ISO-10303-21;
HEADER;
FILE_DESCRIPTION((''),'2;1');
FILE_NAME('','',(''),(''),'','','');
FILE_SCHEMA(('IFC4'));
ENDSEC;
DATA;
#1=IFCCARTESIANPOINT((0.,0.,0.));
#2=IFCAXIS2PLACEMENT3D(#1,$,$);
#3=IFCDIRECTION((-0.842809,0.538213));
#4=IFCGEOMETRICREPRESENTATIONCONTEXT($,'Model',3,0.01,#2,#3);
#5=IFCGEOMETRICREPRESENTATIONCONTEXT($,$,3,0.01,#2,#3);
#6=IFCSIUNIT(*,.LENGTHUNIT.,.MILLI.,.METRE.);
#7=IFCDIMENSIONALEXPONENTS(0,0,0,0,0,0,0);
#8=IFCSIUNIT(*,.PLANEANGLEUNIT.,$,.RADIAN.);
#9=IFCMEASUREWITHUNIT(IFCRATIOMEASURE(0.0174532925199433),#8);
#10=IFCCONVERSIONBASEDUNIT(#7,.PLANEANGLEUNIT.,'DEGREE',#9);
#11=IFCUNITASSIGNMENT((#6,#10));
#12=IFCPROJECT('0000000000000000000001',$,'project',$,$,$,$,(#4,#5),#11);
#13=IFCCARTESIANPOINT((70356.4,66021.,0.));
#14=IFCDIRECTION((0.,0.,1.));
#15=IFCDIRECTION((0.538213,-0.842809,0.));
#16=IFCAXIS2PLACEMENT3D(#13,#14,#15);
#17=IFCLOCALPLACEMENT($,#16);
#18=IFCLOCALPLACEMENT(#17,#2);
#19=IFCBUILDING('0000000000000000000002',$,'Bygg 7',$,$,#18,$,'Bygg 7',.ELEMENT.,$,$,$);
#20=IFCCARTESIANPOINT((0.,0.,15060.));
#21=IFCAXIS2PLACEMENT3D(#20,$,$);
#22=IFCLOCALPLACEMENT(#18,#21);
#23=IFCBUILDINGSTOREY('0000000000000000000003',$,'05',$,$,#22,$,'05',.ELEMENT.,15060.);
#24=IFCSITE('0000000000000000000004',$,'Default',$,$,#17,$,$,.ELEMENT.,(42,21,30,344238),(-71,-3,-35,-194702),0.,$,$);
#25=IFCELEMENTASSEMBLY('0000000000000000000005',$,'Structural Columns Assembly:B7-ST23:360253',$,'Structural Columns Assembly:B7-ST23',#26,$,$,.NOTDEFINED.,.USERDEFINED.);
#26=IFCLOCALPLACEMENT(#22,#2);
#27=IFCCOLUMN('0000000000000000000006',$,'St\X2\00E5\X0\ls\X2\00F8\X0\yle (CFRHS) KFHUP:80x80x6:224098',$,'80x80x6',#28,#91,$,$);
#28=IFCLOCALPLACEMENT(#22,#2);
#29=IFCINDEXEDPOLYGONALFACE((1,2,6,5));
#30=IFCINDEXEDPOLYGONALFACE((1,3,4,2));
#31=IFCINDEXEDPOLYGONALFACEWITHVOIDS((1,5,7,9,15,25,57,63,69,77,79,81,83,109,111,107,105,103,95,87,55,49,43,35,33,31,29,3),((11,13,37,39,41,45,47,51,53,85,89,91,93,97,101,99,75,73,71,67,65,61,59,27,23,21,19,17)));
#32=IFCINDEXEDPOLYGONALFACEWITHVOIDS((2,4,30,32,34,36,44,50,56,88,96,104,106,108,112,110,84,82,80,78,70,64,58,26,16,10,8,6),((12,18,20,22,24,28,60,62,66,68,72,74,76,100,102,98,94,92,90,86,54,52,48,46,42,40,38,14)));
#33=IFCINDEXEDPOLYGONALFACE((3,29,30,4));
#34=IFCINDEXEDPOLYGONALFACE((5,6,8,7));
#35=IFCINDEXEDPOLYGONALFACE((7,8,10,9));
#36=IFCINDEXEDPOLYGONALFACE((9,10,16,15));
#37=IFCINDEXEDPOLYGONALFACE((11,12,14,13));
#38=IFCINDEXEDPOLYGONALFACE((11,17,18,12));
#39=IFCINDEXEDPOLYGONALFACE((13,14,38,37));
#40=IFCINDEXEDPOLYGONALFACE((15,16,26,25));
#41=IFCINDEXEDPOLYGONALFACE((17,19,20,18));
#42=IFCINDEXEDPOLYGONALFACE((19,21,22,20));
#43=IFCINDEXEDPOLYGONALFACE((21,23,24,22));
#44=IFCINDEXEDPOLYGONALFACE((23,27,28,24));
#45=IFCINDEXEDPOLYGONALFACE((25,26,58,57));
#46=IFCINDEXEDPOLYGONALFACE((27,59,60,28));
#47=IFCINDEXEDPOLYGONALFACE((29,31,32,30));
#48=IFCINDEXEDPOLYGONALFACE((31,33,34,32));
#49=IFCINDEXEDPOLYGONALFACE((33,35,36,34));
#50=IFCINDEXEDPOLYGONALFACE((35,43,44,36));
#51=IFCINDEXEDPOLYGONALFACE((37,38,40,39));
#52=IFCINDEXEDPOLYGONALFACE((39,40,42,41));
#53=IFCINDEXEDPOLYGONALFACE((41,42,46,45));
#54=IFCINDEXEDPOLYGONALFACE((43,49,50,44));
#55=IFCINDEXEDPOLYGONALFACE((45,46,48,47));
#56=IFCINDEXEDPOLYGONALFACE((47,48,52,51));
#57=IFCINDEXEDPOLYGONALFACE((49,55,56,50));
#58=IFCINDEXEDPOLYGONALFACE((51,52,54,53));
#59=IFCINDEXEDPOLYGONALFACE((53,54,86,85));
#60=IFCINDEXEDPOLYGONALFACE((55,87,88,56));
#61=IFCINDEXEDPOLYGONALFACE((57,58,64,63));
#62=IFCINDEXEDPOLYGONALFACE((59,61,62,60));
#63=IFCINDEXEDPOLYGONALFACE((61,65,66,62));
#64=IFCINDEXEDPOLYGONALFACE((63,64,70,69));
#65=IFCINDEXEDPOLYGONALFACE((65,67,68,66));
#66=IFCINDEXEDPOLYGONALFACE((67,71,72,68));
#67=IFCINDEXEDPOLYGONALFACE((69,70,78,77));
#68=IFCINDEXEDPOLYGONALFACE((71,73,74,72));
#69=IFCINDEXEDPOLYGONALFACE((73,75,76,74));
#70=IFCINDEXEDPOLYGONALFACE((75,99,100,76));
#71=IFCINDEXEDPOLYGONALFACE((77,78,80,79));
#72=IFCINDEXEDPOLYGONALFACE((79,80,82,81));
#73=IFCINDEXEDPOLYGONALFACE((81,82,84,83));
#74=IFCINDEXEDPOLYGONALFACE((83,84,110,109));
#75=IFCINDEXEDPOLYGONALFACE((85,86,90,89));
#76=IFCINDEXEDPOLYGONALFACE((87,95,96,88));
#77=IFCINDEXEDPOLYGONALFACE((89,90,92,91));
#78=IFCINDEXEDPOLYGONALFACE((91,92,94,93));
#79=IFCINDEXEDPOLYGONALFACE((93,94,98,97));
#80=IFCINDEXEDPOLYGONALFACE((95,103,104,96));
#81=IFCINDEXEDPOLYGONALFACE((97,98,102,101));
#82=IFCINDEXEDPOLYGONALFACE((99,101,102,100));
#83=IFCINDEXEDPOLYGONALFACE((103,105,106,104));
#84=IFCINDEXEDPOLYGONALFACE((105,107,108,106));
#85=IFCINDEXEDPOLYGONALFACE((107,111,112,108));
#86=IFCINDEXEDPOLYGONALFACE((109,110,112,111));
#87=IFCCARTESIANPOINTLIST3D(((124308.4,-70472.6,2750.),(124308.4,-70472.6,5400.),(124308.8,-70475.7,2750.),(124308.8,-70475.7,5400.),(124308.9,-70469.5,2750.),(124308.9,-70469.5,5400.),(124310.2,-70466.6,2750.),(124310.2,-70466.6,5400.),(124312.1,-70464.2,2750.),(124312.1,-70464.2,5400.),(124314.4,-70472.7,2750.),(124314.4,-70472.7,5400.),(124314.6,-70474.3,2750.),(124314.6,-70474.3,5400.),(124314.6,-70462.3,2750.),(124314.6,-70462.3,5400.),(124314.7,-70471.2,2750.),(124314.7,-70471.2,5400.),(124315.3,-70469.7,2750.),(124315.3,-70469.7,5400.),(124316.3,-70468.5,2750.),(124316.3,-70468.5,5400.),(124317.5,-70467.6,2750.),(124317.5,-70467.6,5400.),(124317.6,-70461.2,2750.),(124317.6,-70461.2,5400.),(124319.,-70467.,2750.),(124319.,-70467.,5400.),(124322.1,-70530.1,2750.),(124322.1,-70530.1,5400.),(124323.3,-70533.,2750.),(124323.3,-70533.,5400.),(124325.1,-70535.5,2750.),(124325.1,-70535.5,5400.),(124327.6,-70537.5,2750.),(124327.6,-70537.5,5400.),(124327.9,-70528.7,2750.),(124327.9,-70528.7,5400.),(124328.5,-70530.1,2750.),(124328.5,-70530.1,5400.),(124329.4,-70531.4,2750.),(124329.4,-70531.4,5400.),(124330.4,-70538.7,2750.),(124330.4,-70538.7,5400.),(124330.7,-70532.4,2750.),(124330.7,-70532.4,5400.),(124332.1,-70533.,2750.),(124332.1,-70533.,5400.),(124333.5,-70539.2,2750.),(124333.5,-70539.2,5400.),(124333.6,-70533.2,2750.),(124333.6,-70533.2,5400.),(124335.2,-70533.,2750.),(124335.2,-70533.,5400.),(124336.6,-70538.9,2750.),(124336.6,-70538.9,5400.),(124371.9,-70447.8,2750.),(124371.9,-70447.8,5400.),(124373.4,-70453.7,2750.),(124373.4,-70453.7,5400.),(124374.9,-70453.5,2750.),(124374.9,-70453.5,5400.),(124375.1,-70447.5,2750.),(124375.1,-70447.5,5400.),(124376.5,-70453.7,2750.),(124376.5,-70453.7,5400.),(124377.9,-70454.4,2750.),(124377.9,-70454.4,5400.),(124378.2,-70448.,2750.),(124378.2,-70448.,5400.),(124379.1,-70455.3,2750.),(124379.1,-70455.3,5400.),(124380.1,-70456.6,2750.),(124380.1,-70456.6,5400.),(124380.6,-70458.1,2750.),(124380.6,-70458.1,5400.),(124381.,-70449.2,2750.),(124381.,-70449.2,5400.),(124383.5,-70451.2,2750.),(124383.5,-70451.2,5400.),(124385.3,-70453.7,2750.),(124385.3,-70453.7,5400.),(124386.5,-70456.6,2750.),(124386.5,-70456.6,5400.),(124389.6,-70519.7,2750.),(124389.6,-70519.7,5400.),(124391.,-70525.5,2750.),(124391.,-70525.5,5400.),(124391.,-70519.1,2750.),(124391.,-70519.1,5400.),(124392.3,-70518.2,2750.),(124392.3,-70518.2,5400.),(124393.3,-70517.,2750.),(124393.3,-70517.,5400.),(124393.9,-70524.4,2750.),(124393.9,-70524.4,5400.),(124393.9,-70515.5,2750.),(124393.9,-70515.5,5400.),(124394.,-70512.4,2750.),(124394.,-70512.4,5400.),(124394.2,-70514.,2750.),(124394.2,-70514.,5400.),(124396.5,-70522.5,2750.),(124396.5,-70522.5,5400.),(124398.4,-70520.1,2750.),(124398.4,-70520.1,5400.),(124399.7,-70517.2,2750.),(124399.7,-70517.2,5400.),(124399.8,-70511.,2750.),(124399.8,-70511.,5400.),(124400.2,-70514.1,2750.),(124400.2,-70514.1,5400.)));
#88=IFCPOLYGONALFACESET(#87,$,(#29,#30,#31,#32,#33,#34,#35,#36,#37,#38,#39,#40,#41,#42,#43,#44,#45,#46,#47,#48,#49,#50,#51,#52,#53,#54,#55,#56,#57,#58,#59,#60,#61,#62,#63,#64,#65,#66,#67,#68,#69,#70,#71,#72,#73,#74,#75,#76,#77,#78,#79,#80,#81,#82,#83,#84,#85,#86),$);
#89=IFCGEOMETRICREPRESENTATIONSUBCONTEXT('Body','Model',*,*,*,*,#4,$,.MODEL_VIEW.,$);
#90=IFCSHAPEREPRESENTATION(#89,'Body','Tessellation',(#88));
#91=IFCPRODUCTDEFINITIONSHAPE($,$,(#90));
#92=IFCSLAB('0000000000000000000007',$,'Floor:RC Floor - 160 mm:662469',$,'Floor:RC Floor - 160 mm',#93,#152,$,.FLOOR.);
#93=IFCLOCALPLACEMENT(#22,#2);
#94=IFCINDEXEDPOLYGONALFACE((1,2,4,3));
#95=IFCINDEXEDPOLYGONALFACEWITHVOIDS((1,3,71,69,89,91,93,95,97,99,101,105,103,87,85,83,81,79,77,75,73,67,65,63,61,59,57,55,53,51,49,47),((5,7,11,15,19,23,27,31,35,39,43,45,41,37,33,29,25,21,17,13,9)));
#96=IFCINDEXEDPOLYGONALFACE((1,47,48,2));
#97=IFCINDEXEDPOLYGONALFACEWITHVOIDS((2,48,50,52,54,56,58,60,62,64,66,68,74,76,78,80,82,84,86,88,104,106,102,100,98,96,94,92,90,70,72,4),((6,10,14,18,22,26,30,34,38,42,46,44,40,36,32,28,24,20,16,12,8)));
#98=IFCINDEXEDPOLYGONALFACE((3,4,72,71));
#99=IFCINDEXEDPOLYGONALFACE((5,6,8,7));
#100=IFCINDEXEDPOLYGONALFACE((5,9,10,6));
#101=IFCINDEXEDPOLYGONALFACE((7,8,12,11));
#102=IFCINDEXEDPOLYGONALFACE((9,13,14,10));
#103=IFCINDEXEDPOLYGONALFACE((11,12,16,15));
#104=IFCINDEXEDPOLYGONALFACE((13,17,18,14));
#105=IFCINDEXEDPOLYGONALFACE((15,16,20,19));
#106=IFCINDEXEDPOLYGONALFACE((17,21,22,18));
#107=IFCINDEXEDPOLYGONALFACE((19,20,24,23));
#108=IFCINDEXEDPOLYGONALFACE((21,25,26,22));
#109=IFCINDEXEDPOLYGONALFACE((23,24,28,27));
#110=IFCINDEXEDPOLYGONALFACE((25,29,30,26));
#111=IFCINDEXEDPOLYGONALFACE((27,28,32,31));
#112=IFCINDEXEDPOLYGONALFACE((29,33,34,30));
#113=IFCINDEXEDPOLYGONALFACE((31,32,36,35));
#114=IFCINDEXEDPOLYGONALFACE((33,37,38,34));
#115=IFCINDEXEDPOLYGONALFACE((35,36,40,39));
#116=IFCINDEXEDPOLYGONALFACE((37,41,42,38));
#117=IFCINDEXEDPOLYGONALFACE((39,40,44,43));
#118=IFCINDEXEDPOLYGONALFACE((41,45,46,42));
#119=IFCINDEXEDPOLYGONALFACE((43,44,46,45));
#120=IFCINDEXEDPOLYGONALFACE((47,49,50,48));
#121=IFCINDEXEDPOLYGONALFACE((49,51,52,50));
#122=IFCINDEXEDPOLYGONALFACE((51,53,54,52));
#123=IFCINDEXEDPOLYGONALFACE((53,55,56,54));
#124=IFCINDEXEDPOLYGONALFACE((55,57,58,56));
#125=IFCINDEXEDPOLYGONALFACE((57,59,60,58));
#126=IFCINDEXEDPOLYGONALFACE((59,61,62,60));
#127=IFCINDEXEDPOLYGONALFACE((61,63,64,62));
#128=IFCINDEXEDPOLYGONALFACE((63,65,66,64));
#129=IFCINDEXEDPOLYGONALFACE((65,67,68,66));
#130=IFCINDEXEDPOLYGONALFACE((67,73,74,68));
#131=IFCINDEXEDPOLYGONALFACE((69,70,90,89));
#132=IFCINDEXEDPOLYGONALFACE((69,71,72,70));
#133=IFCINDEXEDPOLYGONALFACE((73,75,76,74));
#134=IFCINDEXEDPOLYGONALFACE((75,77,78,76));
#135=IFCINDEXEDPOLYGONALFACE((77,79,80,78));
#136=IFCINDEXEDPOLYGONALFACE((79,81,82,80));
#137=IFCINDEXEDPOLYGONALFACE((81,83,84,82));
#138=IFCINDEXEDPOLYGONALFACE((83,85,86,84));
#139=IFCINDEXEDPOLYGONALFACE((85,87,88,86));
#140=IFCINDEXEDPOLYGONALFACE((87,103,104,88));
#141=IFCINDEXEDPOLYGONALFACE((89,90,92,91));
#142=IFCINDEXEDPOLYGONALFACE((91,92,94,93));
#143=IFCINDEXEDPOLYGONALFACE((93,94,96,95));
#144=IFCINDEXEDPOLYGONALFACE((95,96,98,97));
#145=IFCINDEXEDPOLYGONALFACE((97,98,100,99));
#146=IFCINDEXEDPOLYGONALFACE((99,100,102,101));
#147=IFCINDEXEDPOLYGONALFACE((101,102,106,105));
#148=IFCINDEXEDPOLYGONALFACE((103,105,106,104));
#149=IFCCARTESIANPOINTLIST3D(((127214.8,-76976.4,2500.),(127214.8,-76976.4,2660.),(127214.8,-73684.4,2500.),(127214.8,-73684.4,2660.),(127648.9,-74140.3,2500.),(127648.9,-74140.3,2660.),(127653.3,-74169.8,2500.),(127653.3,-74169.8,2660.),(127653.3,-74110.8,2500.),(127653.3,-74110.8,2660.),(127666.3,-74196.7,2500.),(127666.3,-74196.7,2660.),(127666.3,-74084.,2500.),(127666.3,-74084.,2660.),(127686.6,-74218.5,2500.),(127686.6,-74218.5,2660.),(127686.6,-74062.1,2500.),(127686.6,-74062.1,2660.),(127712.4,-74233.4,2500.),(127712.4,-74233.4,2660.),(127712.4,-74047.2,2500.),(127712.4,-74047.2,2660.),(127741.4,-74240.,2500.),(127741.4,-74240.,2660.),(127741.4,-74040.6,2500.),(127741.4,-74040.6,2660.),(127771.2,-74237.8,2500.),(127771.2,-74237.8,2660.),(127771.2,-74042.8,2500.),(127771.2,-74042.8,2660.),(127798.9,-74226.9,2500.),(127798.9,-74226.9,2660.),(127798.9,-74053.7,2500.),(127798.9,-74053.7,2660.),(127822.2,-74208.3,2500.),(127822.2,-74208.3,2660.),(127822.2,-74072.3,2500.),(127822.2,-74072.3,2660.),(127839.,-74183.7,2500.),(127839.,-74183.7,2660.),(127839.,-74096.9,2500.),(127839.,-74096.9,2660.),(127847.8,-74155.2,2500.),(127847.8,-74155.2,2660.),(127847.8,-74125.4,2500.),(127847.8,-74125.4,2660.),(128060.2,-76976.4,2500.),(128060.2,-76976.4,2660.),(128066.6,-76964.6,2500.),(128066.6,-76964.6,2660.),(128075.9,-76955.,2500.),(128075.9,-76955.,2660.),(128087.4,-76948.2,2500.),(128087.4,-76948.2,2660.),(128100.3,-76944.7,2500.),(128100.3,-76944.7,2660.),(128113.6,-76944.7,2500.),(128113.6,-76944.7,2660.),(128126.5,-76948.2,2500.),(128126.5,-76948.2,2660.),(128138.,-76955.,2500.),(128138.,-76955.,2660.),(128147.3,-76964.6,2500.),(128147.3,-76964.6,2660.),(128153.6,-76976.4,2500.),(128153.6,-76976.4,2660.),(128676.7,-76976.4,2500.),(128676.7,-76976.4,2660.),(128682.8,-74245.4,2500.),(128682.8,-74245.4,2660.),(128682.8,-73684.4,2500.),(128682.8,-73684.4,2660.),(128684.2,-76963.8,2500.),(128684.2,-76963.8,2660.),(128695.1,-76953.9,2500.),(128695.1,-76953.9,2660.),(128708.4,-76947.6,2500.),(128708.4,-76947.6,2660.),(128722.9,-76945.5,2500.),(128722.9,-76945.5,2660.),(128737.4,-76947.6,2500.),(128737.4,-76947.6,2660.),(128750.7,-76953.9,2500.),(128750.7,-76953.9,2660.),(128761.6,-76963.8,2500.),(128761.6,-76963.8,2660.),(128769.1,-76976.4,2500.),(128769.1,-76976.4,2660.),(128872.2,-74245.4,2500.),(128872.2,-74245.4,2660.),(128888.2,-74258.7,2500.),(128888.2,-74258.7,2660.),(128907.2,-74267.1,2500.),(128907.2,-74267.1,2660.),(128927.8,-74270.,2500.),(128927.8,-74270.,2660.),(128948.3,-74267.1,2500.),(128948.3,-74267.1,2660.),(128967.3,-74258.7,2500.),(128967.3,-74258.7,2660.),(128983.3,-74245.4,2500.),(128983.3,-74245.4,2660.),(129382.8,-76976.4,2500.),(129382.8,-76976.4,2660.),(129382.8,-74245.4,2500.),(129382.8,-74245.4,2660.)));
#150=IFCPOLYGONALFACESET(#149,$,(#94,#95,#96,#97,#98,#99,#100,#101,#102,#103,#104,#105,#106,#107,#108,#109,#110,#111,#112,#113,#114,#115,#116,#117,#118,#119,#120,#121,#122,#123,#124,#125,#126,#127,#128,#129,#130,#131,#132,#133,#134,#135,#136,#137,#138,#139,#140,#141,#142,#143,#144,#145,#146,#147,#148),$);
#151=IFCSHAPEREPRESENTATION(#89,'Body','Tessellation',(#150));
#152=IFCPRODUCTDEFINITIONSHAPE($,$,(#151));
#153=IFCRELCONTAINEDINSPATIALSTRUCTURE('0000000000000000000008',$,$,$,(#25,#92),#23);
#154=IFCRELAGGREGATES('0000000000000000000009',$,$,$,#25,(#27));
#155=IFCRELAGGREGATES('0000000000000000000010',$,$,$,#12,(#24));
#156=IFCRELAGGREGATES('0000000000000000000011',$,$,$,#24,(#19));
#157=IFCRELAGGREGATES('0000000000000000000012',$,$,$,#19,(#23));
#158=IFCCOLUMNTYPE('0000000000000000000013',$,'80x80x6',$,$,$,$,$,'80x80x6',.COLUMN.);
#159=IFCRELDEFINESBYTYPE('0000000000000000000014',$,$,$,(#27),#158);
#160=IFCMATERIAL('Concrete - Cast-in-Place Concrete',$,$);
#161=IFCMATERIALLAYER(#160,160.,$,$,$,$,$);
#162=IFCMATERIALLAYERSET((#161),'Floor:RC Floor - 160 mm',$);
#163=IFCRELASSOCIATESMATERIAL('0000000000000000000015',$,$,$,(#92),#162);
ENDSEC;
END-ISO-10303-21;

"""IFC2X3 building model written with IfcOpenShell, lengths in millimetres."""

from ifc_helpers import new_model, entity, si_unit, converted_unit, direction, frame, frame_2d, origin, place, context, subcontext, project, spatial, polyline, circle_curve, parameter, trimmed, segment, composite_curve, circle, outline, extrude, source, transform, mapped, material, layer, layer_set, layer_usage, type_object, type_shapes, element, aggregate, save


model = new_model("IFC2X3")

# Units and contexts
model_context = context("Model", 3, precision=0.01, world=origin(), true_north=direction((-0.842809, 0.538213)))
context_of_model = context(None, 3, precision=0.01, world=origin(), true_north=direction((-0.842809, 0.538213)))
body_context = subcontext(model_context, "Body", "Model", "MODEL_VIEW")
ifc_project = project(units=[si_unit("LENGTHUNIT", "METRE", prefix="MILLI"), converted_unit("PLANEANGLEUNIT", "DEGREE", entity("IfcRatioMeasure", 0.0174532925199433), si_unit("PLANEANGLEUNIT", "RADIAN"), dimensions=[0, 0, 0, 0, 0, 0, 0])], contexts=[model_context, context_of_model])

# Site, building, storey
site_placement = place(None, frame((70356.4, 66021.0, 0.0), z_axis=(0.0, 0.0, 1.0), x_axis=(0.538213, -0.842809, 0.0)))
site = spatial("IfcSite", under=ifc_project, at=site_placement, Name="Default", CompositionType="ELEMENT", RefLatitude=(42, 21, 30, 344238), RefLongitude=(-71, -3, -35, -194702), RefElevation=0.0)
building_placement = place(site_placement, origin())
building = spatial("IfcBuilding", under=site, at=building_placement, Name="Bygg 7", LongName="Bygg 7", CompositionType="ELEMENT")
storey_placement = place(building_placement, frame((0.0, 0.0, 15060.0)))
storey = spatial("IfcBuildingStorey", under=building, at=storey_placement, Name="05", LongName="05", CompositionType="ELEMENT", Elevation=15060.0)

# Element assembly, column
assembly_1_placement = place(storey_placement, origin())
assembly_1 = element("IfcElementAssembly", 1, at=assembly_1_placement, inside=storey, Name="Structural Columns Assembly:B7-ST23:360253", ObjectType="Structural Columns Assembly:B7-ST23", AssemblyPlace="NOTDEFINED", PredefinedType="USERDEFINED")
column_type_1 = type_object("IfcColumnType", Name="80x80x6", ElementType="80x80x6", PredefinedType="COLUMN")
shared_shape_1 = source(origin(), body_context, "Body", "SweptSolid", [
    extrude(outline(composite_curve([segment(trimmed(circle_curve(frame_2d((-28.0, 28.0), x_axis=(1.0, 0.0)), 12.0), [parameter(90.0)], [parameter(180.0)], True, "PARAMETER"), True, "CONTINUOUS"), segment(polyline([(-40.0, 28.0), (-40.0, -28.0)]), True, "CONTINUOUS"), segment(trimmed(circle_curve(frame_2d((-28.0, -28.0), x_axis=(1.0, 0.0)), 12.0), [parameter(180.0)], [parameter(270.0)], True, "PARAMETER"), True, "CONTINUOUS"), segment(polyline([(-28.0, -40.0), (28.0, -40.0)]), True, "CONTINUOUS"), segment(trimmed(circle_curve(frame_2d((28.0, -28.0), x_axis=(1.0, 0.0)), 12.0), [parameter(270.0)], [parameter(0.0)], True, "PARAMETER"), True, "CONTINUOUS"), segment(polyline([(40.0, -28.0), (40.0, 28.0)]), True, "CONTINUOUS"), segment(trimmed(circle_curve(frame_2d((28.0, 28.0), x_axis=(1.0, 0.0)), 12.0), [parameter(0.0)], [parameter(90.0)], True, "PARAMETER"), True, "CONTINUOUS"), segment(polyline([(28.0, 40.0), (-28.0, 40.0)]), True, "CONTINUOUS")], self_intersect=False), holes=[composite_curve([segment(polyline([(-28.0, 34.0), (28.0, 34.0)]), True, "CONTINUOUS"), segment(trimmed(circle_curve(frame_2d((28.0, 28.0), x_axis=(1.0, 0.0)), 6.0), [parameter(360.0)], [parameter(90.0)], True, "PARAMETER"), False, "CONTINUOUS"), segment(polyline([(34.0, 28.0), (34.0, -28.0)]), True, "CONTINUOUS"), segment(trimmed(circle_curve(frame_2d((28.0, -28.0), x_axis=(1.0, 0.0)), 6.0), [parameter(270.0)], [parameter(360.0)], True, "PARAMETER"), False, "CONTINUOUS"), segment(polyline([(28.0, -34.0), (-28.0, -34.0)]), True, "CONTINUOUS"), segment(trimmed(circle_curve(frame_2d((-28.0, -28.0), x_axis=(1.0, 0.0)), 6.0), [parameter(180.0)], [parameter(270.0)], True, "PARAMETER"), False, "CONTINUOUS"), segment(polyline([(-34.0, -28.0), (-34.0, 28.0)]), True, "CONTINUOUS"), segment(trimmed(circle_curve(frame_2d((-28.0, 28.0), x_axis=(1.0, 0.0)), 6.0), [parameter(90.0)], [parameter(180.0)], True, "PARAMETER"), False, "CONTINUOUS")], self_intersect=False)]), frame((47.5, 47.5, 0.0), z_axis=(0.0, 0.0, 1.0), x_axis=(-0.971172, -0.238381, 0.0)), (0.0, 0.0, 1.0), 2650.0),
])
type_shapes(column_type_1, [shared_shape_1])
column_1_placement = place(assembly_1_placement, frame((124306.8, -70540.8, 2750.0)))
column_1 = element("IfcColumn", 2, at=column_1_placement, type_object=column_type_1, Name="Stålsøyle (CFRHS) KFHUP:80x80x6:224098", ObjectType="80x80x6", context=body_context, shape_type="MappedRepresentation", body=[
    mapped(shared_shape_1, transform((0.0, 0.0, 0.0), scale=1.0)),
])
aggregate(assembly_1, [column_1])

# Shared definitions
ifc_material_1 = material(Name="Concrete - Cast-in-Place Concrete")

# Slab, openings
ifc_layer_1 = layer(ifc_material_1, 160.0)
ifc_layer_set_1 = layer_set([ifc_layer_1], Name="Floor:RC Floor - 160 mm")
ifc_layer_usage_1 = layer_usage(ifc_layer_set_1, "AXIS3", "POSITIVE", 0.0)
slab_1_placement = place(storey_placement, frame((127214.8, -76976.4, 2500.0)))
slab_1 = element("IfcSlab", 3, at=slab_1_placement, inside=storey, material=ifc_layer_usage_1, Name="Floor:RC Floor - 160 mm:662469", ObjectType="Floor:RC Floor - 160 mm", PredefinedType="FLOOR", context=body_context, shape_type="SweptSolid", body=[
    extrude(outline(polyline([(-384.0, 1646.0), (-384.0, 1085.0), (-1084.0, 1085.0), (-1084.0, -1646.0), (1084.0, -1646.0), (1084.0, 1646.0), (-384.0, 1646.0)])), frame((1084.0, 1646.0, 160.0), z_axis=(0.0, 0.0, -1.0), x_axis=(-1.0, 0.0, 0.0)), (0.0, 0.0, 1.0), 160.0),
])
opening_1_placement = place(storey_placement, frame((127214.8, -76976.4, 2500.0)))
element("IfcOpeningElement", 4, at=opening_1_placement, cuts=slab_1, ObjectType="Opening", context=body_context, shape_type="SweptSolid", body=[
    extrude(circle(Radius=100.0, at=frame_2d((549.9, 1190.0), x_axis=(1.0, 0.0))), frame((1084.0, 1646.0, 160.0), z_axis=(0.0, 0.0, -1.0), x_axis=(-1.0, 0.0, 0.0)), (0.0, 0.0, 1.0), 160.0),
])
opening_2_placement = place(storey_placement, frame((127214.8, -76976.4, 2500.0)))
element("IfcOpeningElement", 5, at=opening_2_placement, cuts=slab_1, ObjectType="Opening", context=body_context, shape_type="SweptSolid", body=[
    extrude(circle(Radius=75.0, at=frame_2d((-628.9, 1135.4), x_axis=(1.0, 0.0))), frame((1084.0, 1646.0, 160.0), z_axis=(0.0, 0.0, -1.0), x_axis=(-1.0, 0.0, 0.0)), (0.0, 0.0, 1.0), 160.0),
])
opening_3_placement = place(storey_placement, frame((127214.8, -76976.4, 2500.0)))
element("IfcOpeningElement", 6, at=opening_3_placement, cuts=slab_1, ObjectType="Opening", context=body_context, shape_type="SweptSolid", body=[
    extrude(circle(Radius=50.0, at=frame_2d((191.9, -1663.8), x_axis=(1.0, 0.0))), frame((1084.0, 1646.0, 160.0), z_axis=(0.0, 0.0, -1.0), x_axis=(-1.0, 0.0, 0.0)), (0.0, 0.0, 1.0), 160.0),
])
opening_4_placement = place(storey_placement, frame((127214.8, -76976.4, 2500.0)))
element("IfcOpeningElement", 7, at=opening_4_placement, cuts=slab_1, ObjectType="Opening", context=body_context, shape_type="SweptSolid", body=[
    extrude(circle(Radius=50.0, at=frame_2d((-424.1, -1665.1), x_axis=(1.0, 0.0))), frame((1084.0, 1646.0, 160.0), z_axis=(0.0, 0.0, -1.0), x_axis=(-1.0, 0.0, 0.0)), (0.0, 0.0, 1.0), 160.0),
])

save(model, "model.ifc")
